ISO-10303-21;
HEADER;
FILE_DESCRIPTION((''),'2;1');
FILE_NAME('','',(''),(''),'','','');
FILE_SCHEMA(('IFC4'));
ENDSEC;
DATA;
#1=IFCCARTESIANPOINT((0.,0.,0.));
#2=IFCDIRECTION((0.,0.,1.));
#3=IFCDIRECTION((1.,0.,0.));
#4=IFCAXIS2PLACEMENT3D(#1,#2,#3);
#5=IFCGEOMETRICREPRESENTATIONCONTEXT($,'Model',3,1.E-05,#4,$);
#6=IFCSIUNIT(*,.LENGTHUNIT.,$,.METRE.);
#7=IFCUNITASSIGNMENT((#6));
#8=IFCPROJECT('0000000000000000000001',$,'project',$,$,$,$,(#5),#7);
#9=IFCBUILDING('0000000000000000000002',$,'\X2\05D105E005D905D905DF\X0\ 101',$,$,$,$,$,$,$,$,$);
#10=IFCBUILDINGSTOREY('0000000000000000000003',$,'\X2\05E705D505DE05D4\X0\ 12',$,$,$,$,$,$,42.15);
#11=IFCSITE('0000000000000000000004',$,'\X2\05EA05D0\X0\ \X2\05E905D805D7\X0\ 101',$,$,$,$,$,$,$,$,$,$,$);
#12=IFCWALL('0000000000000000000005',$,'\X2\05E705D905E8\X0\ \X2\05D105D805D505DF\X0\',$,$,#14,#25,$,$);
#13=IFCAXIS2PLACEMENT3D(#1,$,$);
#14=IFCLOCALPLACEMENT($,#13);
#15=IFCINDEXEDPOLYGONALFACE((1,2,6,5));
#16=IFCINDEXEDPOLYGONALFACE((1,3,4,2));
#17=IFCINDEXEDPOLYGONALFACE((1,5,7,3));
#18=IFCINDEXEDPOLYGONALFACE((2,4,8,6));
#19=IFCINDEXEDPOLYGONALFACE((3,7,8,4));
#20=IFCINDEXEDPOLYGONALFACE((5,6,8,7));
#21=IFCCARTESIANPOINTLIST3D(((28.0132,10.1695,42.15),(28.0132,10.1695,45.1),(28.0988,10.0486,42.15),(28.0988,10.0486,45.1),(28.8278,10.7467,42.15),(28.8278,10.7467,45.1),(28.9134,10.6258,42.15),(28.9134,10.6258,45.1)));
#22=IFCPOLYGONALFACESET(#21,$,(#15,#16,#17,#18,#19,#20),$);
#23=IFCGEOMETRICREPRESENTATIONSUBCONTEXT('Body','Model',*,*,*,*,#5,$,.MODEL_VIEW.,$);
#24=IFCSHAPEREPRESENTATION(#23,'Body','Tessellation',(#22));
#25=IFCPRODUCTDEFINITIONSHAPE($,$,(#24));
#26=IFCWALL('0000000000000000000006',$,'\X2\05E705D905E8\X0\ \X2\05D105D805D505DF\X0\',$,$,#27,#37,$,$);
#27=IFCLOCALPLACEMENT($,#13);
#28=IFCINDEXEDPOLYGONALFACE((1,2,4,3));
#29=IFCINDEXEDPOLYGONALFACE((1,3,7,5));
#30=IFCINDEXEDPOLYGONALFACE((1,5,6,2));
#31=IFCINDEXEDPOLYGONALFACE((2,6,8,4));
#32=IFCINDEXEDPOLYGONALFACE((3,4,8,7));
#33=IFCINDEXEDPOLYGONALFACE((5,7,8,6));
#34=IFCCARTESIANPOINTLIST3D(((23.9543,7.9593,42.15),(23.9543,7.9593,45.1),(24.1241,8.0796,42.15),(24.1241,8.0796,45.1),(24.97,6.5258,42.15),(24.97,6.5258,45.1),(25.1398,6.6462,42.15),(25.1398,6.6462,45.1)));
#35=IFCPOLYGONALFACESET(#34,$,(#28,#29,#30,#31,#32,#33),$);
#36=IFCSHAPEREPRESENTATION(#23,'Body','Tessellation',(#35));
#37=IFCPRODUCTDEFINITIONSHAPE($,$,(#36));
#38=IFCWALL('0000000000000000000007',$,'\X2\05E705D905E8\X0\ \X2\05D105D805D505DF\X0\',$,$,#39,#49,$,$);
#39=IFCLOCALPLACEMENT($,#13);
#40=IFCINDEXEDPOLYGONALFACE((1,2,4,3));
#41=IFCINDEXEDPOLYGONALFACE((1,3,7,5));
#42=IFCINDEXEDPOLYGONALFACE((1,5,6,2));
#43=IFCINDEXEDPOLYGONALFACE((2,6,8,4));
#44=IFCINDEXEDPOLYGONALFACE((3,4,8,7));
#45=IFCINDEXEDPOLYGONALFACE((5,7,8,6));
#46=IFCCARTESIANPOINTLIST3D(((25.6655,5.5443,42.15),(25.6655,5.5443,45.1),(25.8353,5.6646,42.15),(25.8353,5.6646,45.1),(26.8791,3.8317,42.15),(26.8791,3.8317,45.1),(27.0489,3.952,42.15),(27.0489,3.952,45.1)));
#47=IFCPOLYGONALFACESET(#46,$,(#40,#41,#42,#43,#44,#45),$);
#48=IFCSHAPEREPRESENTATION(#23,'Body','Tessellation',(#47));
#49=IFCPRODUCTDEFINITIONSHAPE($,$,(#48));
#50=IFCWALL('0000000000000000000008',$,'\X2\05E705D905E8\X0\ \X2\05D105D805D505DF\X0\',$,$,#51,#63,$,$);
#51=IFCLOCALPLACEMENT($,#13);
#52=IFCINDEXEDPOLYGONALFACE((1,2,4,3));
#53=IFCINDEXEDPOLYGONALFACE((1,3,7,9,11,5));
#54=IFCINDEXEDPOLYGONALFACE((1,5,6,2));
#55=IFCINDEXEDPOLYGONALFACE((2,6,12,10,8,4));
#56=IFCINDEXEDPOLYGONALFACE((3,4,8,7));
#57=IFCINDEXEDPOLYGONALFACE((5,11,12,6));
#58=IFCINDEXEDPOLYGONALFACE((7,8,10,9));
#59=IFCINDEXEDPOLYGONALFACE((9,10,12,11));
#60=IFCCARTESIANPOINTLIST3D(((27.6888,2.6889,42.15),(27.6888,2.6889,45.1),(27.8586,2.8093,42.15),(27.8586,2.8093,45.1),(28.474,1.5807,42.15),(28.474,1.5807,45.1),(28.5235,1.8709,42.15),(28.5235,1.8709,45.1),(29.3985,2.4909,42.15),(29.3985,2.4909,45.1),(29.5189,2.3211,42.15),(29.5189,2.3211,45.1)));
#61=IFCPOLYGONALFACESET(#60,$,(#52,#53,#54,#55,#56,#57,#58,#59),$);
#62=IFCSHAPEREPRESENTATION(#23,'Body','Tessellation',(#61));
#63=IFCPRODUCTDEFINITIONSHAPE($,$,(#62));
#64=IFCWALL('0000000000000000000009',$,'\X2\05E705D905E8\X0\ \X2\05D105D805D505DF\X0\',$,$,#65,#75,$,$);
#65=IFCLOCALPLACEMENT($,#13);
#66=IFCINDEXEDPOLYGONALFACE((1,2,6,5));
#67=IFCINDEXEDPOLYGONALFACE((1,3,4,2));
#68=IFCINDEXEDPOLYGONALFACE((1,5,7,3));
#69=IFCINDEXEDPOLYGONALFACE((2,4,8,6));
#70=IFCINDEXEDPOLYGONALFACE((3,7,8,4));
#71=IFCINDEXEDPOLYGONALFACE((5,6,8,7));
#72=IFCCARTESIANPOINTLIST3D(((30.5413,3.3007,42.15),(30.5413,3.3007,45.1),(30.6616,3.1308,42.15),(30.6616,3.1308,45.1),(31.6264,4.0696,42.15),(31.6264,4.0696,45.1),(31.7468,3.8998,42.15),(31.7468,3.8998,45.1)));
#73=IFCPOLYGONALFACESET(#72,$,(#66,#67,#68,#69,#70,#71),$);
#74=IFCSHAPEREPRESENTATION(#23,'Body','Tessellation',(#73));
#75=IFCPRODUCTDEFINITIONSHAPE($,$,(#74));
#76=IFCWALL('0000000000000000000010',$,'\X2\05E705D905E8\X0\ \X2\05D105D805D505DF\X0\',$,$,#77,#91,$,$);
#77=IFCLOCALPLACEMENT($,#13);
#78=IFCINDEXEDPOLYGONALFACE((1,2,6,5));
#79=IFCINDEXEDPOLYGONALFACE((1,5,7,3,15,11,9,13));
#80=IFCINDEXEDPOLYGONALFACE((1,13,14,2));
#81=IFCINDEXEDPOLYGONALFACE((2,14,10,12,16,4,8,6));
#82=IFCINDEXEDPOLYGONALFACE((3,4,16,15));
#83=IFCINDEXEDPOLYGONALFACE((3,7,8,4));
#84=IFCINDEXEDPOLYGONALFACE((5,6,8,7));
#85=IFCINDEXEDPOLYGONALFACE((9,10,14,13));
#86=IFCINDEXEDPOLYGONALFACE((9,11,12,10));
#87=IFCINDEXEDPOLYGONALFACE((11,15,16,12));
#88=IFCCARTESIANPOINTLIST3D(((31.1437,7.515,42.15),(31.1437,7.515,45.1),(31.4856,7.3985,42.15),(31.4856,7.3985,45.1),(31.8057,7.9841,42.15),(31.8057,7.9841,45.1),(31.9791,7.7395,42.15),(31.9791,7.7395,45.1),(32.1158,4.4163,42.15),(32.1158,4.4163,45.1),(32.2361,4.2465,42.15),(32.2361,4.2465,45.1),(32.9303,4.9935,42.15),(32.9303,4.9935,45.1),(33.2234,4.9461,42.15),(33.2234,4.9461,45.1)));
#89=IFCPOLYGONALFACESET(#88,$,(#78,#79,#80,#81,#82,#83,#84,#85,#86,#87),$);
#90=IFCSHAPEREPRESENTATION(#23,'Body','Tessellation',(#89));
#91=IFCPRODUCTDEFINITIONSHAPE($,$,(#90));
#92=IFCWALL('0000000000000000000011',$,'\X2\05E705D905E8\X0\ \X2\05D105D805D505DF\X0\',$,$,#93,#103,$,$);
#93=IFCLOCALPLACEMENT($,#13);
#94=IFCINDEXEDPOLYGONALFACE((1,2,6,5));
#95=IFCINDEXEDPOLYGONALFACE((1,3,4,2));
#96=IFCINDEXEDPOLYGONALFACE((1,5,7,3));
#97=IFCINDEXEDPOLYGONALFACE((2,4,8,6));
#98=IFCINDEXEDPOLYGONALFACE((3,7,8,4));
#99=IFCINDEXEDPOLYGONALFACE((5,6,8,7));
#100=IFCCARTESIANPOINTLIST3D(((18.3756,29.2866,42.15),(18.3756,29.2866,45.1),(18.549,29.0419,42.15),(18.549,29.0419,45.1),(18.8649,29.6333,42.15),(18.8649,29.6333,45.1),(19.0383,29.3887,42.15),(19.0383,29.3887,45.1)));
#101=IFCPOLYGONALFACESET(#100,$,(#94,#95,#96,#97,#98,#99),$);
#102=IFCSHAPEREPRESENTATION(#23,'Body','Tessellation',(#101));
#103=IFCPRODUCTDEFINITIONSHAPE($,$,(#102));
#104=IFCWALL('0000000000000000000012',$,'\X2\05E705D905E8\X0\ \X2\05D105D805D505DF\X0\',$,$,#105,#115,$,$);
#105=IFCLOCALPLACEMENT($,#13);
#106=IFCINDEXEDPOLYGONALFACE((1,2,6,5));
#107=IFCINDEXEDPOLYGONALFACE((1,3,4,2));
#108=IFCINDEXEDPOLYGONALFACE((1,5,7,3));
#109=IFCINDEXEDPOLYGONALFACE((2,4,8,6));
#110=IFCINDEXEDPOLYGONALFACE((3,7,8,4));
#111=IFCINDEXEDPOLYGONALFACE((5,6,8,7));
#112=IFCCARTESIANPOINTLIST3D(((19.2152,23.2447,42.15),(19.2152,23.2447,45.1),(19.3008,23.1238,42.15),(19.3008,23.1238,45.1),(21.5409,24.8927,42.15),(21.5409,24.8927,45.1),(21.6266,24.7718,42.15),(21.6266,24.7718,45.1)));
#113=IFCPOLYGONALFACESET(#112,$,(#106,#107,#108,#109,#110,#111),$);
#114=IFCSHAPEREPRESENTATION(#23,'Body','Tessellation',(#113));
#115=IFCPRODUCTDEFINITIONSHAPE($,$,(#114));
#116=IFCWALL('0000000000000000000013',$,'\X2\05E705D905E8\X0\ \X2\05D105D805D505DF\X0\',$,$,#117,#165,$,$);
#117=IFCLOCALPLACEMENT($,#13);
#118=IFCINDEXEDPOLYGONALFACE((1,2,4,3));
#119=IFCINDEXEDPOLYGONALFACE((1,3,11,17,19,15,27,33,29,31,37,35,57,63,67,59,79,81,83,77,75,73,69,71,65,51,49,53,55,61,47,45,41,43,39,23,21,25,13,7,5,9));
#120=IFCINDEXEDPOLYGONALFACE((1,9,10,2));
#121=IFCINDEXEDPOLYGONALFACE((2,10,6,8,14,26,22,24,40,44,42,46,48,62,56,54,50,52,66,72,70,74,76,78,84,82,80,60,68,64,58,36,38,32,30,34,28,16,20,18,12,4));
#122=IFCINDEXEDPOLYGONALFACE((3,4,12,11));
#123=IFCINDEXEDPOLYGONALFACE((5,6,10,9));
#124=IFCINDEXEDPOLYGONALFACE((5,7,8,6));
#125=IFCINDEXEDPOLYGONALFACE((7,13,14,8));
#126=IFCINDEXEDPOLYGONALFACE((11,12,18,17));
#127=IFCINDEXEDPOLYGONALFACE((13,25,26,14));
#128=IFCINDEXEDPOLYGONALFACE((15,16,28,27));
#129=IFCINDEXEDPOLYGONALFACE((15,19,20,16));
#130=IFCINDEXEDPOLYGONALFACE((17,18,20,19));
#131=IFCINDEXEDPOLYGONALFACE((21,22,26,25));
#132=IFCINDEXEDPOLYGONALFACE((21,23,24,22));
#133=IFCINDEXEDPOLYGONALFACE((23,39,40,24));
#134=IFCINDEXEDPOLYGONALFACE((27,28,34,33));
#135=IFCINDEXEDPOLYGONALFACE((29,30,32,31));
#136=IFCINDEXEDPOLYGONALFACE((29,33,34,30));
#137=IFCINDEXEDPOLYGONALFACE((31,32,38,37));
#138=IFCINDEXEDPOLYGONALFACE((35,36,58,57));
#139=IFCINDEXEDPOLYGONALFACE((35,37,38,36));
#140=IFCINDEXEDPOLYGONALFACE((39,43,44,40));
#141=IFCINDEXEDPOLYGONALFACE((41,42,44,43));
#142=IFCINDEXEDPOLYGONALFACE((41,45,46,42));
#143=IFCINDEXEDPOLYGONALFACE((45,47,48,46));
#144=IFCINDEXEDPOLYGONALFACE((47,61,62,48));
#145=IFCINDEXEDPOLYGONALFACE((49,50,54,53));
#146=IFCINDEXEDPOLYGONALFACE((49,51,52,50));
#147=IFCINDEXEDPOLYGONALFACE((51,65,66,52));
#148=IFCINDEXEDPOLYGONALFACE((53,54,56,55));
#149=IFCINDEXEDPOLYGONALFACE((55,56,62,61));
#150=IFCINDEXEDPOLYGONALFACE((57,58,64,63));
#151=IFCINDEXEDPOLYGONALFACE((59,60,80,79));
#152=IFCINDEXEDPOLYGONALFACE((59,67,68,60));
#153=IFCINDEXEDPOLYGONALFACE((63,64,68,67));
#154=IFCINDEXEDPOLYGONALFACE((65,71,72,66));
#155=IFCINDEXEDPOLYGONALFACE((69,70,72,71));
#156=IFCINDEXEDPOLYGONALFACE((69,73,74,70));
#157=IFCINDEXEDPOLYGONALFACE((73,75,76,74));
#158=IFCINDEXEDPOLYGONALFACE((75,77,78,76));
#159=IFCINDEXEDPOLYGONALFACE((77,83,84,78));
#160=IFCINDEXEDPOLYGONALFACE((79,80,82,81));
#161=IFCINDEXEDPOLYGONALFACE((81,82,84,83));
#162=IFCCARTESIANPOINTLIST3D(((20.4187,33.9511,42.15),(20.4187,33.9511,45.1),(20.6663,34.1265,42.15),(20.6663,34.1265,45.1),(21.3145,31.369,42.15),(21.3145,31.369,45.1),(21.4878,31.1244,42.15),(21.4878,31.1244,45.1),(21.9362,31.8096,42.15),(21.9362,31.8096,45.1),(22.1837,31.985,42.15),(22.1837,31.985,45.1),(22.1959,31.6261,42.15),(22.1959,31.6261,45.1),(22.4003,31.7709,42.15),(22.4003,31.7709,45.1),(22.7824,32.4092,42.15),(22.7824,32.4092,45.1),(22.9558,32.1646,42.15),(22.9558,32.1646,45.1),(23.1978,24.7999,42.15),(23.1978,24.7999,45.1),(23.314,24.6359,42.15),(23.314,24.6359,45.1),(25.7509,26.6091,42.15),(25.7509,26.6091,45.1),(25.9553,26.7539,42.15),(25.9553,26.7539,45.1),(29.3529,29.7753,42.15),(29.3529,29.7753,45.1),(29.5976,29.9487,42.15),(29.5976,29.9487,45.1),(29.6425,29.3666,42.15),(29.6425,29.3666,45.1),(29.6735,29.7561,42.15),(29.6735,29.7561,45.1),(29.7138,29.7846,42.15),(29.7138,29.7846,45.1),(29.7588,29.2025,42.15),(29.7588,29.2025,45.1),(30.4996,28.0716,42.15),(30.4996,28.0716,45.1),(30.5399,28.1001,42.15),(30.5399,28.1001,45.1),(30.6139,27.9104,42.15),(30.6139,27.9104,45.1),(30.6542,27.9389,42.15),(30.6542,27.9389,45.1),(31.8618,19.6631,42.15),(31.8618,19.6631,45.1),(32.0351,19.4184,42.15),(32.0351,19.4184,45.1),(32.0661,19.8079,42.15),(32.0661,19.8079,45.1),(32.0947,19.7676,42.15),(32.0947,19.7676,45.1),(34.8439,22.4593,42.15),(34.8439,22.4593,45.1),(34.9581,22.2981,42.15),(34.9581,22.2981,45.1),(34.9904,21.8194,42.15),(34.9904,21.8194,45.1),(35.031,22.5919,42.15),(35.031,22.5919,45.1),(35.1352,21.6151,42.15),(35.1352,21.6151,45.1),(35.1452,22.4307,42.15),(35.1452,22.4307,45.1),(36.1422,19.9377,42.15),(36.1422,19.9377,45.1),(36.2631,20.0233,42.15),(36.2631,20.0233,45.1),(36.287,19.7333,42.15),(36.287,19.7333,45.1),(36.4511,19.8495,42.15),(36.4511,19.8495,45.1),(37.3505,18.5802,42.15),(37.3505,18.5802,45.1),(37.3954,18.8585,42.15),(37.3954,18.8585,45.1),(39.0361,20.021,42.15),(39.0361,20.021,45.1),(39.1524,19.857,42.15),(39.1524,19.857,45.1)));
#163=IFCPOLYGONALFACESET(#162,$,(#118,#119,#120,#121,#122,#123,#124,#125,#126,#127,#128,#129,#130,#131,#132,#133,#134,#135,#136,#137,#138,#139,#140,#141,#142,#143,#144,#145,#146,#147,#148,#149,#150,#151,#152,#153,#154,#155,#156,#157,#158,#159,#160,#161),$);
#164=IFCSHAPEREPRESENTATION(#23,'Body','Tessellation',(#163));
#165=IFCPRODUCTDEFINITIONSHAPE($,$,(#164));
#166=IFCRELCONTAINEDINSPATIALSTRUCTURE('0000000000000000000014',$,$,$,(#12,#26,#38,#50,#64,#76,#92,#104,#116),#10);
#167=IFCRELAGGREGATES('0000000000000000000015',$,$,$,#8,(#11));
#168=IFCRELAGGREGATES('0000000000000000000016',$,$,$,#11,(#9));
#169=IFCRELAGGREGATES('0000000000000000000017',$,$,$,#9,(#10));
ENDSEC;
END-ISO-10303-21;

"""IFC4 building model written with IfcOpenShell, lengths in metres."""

from ifc_helpers import new_model, si_unit, frame, origin_with_axes, context, subcontext, project, spatial, polyline, outline, extrude, element, save


model = new_model("IFC4")

# Units and contexts
model_context = context("Model", 3, precision=1e-05, world=origin_with_axes())
body_context = subcontext(model_context, "Body", "Model", "MODEL_VIEW")
ifc_project = project(units=[si_unit("LENGTHUNIT", "METRE")], contexts=[model_context])

# Site, building, storey
site = spatial("IfcSite", under=ifc_project, Name="תא שטח 101")
building = spatial("IfcBuilding", under=site, Name="בניין 101")
storey = spatial("IfcBuildingStorey", under=building, Name="קומה 12", Elevation=42.15)

# Walls
element("IfcWall", 1, inside=storey, Name="קיר בטון", context=body_context, shape_type="SweptSolid", body=[
    extrude(outline(polyline([(28.9134, 10.6258), (28.8278, 10.7467), (28.0132, 10.1695), (28.0988, 10.0486), (28.9134, 10.6258)])), frame((0.0, 0.0, 42.15)), (0.0, 0.0, 1.0), 2.95),
])
element("IfcWall", 2, inside=storey, Name="קיר בטון", context=body_context, shape_type="SweptSolid", body=[
    extrude(outline(polyline([(23.9543, 7.9593), (24.97, 6.5258), (25.1398, 6.6462), (24.1241, 8.0796), (23.9543, 7.9593)])), frame((0.0, 0.0, 42.15)), (0.0, 0.0, 1.0), 2.95),
])
element("IfcWall", 3, inside=storey, Name="קיר בטון", context=body_context, shape_type="SweptSolid", body=[
    extrude(outline(polyline([(25.8353, 5.6646), (25.6655, 5.5443), (26.8791, 3.8317), (27.0489, 3.952), (25.8353, 5.6646)])), frame((0.0, 0.0, 42.15)), (0.0, 0.0, 1.0), 2.95),
])
element("IfcWall", 4, inside=storey, Name="קיר בטון", context=body_context, shape_type="SweptSolid", body=[
    extrude(outline(polyline([(28.474, 1.5807), (29.5189, 2.3211), (29.3985, 2.4909), (28.5235, 1.8709), (27.8586, 2.8093), (27.6888, 2.6889), (28.474, 1.5807)])), frame((0.0, 0.0, 42.15)), (0.0, 0.0, 1.0), 2.95),
])
element("IfcWall", 5, inside=storey, Name="קיר בטון", context=body_context, shape_type="SweptSolid", body=[
    extrude(outline(polyline([(30.5413, 3.3007), (30.6616, 3.1308), (31.7468, 3.8998), (31.6264, 4.0696), (30.5413, 3.3007)])), frame((0.0, 0.0, 42.15)), (0.0, 0.0, 1.0), 2.95),
])
element("IfcWall", 6, inside=storey, Name="קיר בטון", context=body_context, shape_type="SweptSolid", body=[
    extrude(outline(polyline([(32.1158, 4.4163), (32.2361, 4.2465), (33.2234, 4.9461), (31.4856, 7.3985), (31.9791, 7.7395), (31.8057, 7.9841), (31.1437, 7.515), (32.9303, 4.9935), (32.1158, 4.4163)])), frame((0.0, 0.0, 42.15)), (0.0, 0.0, 1.0), 2.95),
])
element("IfcWall", 7, inside=storey, Name="קיר בטון", context=body_context, shape_type="SweptSolid", body=[
    extrude(outline(polyline([(18.3756, 29.2866), (18.549, 29.0419), (19.0383, 29.3887), (18.8649, 29.6333), (18.3756, 29.2866)])), frame((0.0, 0.0, 42.15)), (0.0, 0.0, 1.0), 2.95),
])
element("IfcWall", 8, inside=storey, Name="קיר בטון", context=body_context, shape_type="SweptSolid", body=[
    extrude(outline(polyline([(21.6266, 24.7718), (21.5409, 24.8927), (19.2152, 23.2447), (19.3008, 23.1238), (21.6266, 24.7718)])), frame((0.0, 0.0, 42.15)), (0.0, 0.0, 1.0), 2.95),
])
element("IfcWall", 9, inside=storey, Name="קיר בטון", context=body_context, shape_type="SweptSolid", body=[
    extrude(outline(polyline([(23.314, 24.6359), (29.7588, 29.2025), (30.5399, 28.1001), (30.4996, 28.0716), (30.6139, 27.9104), (30.6542, 27.9389), (34.9904, 21.8194), (32.0947, 19.7676), (32.0661, 19.8079), (31.8618, 19.6631), (32.0351, 19.4184), (35.1352, 21.6151), (36.2631, 20.0233), (36.1422, 19.9377), (36.287, 19.7333), (36.4511, 19.8495), (37.3505, 18.5802), (39.1524, 19.857), (39.0361, 20.021), (37.3954, 18.8585), (34.9581, 22.2981), (35.1452, 22.4307), (35.031, 22.5919), (34.8439, 22.4593), (29.6735, 29.7561), (29.7138, 29.7846), (29.5976, 29.9487), (29.3529, 29.7753), (29.6425, 29.3666), (25.9553, 26.7539), (22.4003, 31.7709), (22.9558, 32.1646), (22.7824, 32.4092), (22.1837, 31.985), (20.6663, 34.1265), (20.4187, 33.9511), (21.9362, 31.8096), (21.3145, 31.369), (21.4878, 31.1244), (22.1959, 31.6261), (25.7509, 26.6091), (23.1978, 24.7999), (23.314, 24.6359)])), frame((0.0, 0.0, 42.15)), (0.0, 0.0, 1.0), 2.95),
])

save(model, "model.ifc")
